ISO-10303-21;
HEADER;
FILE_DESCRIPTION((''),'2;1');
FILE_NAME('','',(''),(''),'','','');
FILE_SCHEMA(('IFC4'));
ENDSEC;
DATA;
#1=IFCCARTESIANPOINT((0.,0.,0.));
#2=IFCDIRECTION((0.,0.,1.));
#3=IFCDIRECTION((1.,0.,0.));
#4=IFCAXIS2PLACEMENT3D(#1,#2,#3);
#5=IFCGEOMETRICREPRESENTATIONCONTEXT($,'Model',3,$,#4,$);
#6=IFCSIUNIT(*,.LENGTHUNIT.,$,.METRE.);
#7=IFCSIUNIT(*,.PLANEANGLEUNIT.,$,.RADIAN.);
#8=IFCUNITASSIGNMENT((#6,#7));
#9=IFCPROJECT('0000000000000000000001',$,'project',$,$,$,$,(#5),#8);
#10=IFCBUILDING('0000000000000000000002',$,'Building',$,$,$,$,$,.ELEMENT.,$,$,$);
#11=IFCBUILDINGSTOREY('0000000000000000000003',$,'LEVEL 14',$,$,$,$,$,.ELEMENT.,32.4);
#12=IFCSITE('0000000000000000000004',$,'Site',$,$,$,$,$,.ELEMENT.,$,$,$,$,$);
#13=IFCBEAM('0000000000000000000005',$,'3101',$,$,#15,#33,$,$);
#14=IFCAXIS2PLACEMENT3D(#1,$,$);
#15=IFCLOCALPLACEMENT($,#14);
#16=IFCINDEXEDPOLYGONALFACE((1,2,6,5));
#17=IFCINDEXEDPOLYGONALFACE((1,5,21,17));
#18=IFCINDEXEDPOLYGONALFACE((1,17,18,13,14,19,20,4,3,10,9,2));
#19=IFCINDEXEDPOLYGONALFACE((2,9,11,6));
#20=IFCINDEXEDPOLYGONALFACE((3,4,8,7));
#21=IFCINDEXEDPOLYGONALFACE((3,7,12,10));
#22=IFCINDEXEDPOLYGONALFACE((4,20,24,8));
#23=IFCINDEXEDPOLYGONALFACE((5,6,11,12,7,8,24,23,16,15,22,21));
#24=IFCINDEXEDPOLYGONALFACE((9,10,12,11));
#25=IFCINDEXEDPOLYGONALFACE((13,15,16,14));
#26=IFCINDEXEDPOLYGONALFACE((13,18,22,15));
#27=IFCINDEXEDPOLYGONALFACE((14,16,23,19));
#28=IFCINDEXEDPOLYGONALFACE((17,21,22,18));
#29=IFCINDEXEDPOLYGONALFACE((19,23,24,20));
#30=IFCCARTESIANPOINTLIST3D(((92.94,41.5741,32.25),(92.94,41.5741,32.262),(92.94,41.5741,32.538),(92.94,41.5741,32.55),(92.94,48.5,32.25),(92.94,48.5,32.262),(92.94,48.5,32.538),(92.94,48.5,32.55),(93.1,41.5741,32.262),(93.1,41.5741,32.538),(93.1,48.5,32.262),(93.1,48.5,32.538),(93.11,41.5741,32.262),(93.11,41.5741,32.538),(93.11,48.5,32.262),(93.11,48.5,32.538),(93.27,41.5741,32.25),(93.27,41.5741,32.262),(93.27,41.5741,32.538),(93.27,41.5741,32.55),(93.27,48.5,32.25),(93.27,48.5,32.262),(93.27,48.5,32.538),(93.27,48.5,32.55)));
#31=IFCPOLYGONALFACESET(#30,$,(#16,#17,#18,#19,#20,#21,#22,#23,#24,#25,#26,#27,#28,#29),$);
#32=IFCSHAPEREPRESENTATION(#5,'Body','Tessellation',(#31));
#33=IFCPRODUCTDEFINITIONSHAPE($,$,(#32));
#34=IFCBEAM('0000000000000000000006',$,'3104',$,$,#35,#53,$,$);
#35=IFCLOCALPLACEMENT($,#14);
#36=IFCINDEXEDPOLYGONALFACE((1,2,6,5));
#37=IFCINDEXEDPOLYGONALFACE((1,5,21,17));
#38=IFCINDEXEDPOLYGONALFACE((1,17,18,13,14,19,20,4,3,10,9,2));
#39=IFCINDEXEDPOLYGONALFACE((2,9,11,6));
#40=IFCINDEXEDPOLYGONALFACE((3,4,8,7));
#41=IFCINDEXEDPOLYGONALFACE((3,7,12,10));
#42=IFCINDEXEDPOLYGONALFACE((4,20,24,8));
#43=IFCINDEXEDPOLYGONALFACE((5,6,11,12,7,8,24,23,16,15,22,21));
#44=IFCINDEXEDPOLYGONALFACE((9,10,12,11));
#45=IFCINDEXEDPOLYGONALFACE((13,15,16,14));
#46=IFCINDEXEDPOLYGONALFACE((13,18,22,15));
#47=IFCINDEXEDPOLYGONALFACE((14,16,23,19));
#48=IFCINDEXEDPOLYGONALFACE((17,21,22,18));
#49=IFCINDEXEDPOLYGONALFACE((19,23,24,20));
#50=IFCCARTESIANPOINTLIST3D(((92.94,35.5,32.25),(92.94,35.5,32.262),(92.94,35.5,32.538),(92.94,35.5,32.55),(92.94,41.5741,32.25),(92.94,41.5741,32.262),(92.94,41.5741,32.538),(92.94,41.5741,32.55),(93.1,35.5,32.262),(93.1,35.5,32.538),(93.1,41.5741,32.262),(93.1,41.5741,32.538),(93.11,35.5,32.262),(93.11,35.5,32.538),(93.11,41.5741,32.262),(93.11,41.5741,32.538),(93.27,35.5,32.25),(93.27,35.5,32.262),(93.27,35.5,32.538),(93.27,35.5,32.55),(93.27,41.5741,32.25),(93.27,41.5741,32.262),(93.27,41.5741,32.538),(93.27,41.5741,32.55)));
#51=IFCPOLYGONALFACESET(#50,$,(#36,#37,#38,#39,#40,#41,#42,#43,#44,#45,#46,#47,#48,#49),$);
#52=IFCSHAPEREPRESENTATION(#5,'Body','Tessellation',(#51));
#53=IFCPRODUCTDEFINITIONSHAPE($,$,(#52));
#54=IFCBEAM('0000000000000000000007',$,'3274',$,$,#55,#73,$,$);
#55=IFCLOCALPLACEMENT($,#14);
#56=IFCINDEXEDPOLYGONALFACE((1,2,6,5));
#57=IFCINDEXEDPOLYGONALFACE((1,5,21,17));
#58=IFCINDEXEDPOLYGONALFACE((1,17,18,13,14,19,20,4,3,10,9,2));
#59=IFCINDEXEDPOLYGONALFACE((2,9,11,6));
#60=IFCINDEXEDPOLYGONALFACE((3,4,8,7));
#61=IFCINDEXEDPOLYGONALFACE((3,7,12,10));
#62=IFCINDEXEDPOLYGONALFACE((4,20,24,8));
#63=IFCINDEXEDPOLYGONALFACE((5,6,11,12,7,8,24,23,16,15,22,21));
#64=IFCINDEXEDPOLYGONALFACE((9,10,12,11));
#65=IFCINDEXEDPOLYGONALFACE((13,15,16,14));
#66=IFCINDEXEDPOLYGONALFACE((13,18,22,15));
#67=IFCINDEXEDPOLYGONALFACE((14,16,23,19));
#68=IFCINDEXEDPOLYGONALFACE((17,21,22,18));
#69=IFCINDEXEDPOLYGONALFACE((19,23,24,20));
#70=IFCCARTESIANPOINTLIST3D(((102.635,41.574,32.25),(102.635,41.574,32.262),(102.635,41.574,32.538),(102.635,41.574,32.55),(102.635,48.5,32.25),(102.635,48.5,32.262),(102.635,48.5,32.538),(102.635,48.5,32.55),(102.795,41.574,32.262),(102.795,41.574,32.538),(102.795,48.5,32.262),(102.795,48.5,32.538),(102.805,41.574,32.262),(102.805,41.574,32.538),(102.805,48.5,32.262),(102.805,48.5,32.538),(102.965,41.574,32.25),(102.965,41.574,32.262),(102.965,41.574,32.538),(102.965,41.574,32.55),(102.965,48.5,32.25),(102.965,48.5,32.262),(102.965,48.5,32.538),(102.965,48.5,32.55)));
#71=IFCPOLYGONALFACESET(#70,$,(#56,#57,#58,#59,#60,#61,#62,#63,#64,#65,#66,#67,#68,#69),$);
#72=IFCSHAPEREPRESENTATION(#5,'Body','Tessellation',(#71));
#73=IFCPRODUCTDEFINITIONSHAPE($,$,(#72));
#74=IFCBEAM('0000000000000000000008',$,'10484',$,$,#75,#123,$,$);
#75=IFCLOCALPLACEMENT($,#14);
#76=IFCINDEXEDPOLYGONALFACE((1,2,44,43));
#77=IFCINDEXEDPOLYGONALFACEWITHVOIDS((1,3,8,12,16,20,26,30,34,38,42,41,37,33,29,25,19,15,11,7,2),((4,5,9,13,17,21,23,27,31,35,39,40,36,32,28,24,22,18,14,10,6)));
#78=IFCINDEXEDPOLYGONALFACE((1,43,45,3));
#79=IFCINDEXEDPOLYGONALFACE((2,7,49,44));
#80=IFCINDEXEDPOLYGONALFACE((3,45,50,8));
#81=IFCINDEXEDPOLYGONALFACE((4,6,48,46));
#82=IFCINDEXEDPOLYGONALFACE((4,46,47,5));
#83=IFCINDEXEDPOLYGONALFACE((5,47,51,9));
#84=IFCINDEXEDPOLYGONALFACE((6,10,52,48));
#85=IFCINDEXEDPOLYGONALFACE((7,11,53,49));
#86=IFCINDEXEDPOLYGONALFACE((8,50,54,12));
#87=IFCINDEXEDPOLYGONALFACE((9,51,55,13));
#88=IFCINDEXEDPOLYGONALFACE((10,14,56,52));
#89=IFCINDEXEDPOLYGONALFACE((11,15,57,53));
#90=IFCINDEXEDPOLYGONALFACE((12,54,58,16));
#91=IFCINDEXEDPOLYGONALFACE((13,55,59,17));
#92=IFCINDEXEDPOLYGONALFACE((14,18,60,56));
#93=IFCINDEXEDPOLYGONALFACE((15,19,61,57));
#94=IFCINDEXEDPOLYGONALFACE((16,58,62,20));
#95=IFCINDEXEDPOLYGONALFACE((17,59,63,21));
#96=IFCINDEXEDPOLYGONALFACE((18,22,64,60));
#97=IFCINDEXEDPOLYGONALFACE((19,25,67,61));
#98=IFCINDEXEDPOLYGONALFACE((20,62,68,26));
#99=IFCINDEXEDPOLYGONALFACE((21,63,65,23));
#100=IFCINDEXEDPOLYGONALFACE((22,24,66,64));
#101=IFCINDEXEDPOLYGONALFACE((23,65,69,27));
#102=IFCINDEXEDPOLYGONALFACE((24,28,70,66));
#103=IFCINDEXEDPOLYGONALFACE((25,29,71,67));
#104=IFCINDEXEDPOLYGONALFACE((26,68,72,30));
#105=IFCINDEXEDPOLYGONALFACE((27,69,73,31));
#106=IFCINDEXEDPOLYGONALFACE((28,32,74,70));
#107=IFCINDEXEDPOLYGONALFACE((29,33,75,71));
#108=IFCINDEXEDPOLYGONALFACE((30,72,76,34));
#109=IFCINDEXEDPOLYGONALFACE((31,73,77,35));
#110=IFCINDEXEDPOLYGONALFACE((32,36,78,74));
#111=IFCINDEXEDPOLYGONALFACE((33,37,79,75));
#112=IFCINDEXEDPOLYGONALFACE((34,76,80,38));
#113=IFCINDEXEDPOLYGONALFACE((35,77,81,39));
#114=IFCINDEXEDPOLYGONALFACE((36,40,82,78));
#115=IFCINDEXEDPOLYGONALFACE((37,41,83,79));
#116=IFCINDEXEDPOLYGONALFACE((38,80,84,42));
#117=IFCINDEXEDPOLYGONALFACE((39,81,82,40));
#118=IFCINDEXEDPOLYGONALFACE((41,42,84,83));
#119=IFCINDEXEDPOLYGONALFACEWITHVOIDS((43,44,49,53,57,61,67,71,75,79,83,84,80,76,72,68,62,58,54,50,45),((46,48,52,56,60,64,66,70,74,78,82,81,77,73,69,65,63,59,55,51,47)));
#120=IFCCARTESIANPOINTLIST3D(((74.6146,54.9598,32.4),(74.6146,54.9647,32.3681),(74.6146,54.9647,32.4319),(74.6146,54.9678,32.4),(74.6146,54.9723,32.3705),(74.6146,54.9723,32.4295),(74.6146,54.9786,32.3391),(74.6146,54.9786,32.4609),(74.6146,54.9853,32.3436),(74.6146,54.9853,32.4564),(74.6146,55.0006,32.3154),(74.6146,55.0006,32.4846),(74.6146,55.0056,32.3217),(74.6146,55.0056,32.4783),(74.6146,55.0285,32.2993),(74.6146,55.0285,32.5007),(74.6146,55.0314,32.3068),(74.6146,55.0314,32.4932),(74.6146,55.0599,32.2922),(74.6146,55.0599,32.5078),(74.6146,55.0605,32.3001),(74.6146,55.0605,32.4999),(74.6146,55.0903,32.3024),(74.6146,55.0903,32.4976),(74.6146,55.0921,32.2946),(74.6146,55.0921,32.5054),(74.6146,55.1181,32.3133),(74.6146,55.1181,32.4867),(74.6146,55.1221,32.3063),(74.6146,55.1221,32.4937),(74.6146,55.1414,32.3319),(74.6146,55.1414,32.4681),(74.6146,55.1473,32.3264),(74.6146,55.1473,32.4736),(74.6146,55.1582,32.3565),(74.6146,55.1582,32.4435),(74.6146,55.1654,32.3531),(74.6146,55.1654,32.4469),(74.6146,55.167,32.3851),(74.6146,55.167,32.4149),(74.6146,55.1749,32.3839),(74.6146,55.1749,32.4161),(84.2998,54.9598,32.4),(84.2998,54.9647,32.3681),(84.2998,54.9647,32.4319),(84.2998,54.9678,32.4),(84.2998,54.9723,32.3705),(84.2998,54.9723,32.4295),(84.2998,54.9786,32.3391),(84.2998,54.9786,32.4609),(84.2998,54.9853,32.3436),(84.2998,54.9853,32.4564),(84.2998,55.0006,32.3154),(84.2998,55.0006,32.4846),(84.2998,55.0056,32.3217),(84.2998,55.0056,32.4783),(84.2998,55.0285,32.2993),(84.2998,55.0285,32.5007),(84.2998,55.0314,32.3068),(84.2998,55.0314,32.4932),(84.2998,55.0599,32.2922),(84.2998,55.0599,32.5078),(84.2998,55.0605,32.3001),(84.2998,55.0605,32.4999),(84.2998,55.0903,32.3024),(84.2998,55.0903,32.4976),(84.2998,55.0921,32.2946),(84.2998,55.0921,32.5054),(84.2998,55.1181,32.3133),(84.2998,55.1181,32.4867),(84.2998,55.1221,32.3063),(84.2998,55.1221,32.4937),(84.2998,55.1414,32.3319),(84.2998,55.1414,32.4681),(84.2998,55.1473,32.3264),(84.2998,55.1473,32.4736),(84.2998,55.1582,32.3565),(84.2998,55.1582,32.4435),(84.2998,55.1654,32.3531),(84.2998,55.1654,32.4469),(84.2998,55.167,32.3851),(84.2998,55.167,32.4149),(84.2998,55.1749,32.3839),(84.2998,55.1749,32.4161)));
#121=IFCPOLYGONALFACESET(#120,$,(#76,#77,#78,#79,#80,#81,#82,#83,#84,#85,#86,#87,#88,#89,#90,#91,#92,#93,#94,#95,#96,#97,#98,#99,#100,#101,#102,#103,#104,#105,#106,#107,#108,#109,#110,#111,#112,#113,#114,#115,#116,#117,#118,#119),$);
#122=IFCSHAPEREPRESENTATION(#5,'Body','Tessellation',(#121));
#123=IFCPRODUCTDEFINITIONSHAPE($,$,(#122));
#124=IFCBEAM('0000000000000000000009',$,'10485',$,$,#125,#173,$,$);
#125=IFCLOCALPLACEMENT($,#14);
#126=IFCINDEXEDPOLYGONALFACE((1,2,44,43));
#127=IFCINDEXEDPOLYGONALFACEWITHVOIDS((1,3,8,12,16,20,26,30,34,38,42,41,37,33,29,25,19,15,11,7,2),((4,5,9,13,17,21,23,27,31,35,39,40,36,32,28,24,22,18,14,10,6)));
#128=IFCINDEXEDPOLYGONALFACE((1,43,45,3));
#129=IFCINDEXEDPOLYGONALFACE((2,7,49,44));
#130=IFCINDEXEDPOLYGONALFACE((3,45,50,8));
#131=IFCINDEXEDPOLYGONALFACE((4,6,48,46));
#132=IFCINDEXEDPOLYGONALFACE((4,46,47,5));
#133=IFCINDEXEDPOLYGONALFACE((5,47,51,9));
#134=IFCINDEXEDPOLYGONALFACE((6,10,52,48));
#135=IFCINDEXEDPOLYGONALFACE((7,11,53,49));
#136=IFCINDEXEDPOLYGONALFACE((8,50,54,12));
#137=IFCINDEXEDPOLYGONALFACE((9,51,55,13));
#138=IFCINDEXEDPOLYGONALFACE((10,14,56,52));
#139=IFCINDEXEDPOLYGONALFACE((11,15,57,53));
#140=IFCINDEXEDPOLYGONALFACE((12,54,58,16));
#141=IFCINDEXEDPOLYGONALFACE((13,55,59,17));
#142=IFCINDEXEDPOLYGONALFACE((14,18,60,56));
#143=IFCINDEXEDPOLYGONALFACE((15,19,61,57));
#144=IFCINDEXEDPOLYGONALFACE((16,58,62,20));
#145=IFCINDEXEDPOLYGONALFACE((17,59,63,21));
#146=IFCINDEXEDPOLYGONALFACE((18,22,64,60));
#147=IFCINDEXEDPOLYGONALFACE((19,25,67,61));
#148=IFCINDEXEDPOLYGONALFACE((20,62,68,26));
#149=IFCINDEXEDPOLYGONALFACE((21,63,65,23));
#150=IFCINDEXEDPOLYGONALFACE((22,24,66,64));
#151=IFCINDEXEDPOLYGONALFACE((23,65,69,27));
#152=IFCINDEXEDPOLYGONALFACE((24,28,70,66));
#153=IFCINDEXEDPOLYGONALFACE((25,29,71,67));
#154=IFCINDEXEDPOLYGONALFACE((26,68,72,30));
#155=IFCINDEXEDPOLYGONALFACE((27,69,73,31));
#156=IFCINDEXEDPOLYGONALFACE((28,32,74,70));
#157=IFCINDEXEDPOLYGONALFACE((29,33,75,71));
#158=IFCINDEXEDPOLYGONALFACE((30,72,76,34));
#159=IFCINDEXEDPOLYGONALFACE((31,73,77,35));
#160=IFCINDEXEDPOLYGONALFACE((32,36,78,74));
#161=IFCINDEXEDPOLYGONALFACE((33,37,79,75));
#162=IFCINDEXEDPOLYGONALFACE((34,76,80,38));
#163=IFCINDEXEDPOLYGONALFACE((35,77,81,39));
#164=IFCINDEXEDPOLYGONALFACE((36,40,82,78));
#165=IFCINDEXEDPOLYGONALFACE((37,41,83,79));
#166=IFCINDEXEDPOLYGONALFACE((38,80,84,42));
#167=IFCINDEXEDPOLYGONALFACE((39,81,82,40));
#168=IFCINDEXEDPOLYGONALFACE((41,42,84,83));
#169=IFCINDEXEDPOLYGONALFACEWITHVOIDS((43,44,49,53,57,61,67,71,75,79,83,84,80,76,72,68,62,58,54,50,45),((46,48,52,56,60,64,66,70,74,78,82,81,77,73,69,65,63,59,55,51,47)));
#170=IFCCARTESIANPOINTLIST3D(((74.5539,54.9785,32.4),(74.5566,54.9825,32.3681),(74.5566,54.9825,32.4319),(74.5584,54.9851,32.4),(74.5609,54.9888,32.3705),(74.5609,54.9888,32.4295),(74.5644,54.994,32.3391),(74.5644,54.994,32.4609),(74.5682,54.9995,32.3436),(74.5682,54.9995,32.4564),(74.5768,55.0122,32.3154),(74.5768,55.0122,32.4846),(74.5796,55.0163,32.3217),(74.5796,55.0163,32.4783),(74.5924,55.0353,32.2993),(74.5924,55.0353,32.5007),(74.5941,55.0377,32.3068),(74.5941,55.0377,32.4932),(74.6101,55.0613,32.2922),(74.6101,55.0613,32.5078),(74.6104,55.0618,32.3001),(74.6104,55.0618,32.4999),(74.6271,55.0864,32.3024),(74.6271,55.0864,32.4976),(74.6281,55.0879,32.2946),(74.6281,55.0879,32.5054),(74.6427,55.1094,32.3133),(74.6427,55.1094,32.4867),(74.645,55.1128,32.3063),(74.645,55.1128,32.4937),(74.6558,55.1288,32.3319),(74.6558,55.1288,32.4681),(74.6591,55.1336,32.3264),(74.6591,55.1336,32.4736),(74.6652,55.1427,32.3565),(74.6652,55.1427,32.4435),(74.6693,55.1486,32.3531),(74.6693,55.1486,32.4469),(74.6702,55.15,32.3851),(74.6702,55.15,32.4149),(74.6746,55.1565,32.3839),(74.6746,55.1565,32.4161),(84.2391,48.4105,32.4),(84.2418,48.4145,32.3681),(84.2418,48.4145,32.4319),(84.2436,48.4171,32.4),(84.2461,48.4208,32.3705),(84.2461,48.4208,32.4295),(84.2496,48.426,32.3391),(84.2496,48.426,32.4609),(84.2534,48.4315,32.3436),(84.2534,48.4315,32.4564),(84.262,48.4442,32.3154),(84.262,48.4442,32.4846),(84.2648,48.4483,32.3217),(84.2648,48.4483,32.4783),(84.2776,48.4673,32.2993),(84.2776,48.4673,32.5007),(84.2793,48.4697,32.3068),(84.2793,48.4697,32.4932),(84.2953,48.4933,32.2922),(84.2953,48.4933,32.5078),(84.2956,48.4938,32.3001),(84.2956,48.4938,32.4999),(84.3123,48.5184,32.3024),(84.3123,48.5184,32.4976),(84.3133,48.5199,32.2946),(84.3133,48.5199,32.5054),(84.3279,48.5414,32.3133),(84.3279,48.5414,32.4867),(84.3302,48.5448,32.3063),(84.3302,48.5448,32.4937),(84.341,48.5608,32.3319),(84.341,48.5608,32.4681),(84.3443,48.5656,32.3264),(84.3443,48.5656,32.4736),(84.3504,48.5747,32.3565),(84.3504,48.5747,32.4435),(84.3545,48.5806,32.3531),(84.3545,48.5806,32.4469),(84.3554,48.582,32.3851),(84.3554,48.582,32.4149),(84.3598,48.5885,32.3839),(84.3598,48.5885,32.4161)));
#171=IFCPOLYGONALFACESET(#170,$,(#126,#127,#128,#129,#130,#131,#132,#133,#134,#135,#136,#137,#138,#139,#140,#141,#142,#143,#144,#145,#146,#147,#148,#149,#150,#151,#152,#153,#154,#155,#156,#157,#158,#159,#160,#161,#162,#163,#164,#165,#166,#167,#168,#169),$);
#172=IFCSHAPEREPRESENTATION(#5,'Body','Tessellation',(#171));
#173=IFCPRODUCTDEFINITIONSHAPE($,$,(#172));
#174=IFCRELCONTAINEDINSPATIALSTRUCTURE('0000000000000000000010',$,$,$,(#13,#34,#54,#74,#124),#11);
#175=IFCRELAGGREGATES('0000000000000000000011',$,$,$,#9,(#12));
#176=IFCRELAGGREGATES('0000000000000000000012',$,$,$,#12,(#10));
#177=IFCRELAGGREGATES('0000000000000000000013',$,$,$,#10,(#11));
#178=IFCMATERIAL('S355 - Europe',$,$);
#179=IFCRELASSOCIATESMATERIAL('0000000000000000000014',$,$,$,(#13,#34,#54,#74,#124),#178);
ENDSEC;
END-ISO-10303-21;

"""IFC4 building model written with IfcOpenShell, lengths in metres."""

from ifc_helpers import new_model, si_unit, frame, origin_with_axes, origin_2d_with_axis, place, context, project, spatial, hollow_circle, i_section, extrude, material, material_profile, profile_set, profile_usage, element, save


model = new_model("IFC4")

# Units and contexts
model_context = context("Model", 3, world=origin_with_axes())
ifc_project = project(units=[si_unit("LENGTHUNIT", "METRE"), si_unit("PLANEANGLEUNIT", "RADIAN")], contexts=[model_context])

# Site, building, storey
site = spatial("IfcSite", under=ifc_project, Name="Site", CompositionType="ELEMENT")
building = spatial("IfcBuilding", under=site, Name="Building", CompositionType="ELEMENT")
storey = spatial("IfcBuildingStorey", under=building, Name="LEVEL 14", CompositionType="ELEMENT", Elevation=32.4)

# Shared definitions
ifc_material = material(Name="S355 - Europe")

# Beams
ifc_material_profile_1 = material_profile(ifc_material, i_section(OverallWidth=0.33, OverallDepth=0.3, WebThickness=0.01, FlangeThickness=0.012, at=origin_2d_with_axis()))
ifc_profile_set_1 = profile_set([ifc_material_profile_1])
ifc_profile_usage_1 = profile_usage(ifc_profile_set_1, cardinal=10)
beam_1_placement = place(None, frame((93.105, 48.5, 32.4), z_axis=(0.0, -1.0, 0.0), x_axis=(1.0, 0.0, 0.0)))
element("IfcBeam", 1, at=beam_1_placement, inside=storey, material=ifc_profile_usage_1, Name="3101", context=model_context, shape_type="SweptSolid", body=[
    extrude(i_section(OverallWidth=0.33, OverallDepth=0.3, WebThickness=0.01, FlangeThickness=0.012, at=origin_2d_with_axis()), origin_with_axes(), (0.0, 0.0, 1.0), 6.9259),
])
ifc_material_profile_2 = material_profile(ifc_material, i_section(OverallWidth=0.33, OverallDepth=0.3, WebThickness=0.01, FlangeThickness=0.012, at=origin_2d_with_axis()))
ifc_profile_set_2 = profile_set([ifc_material_profile_2])
ifc_profile_usage_2 = profile_usage(ifc_profile_set_2, cardinal=10)
beam_2_placement = place(None, frame((93.105, 41.5741, 32.4), z_axis=(0.0, -1.0, 0.0), x_axis=(1.0, 0.0, 0.0)))
element("IfcBeam", 2, at=beam_2_placement, inside=storey, material=ifc_profile_usage_2, Name="3104", context=model_context, shape_type="SweptSolid", body=[
    extrude(i_section(OverallWidth=0.33, OverallDepth=0.3, WebThickness=0.01, FlangeThickness=0.012, at=origin_2d_with_axis()), origin_with_axes(), (0.0, 0.0, 1.0), 6.0741),
])
ifc_material_profile_3 = material_profile(ifc_material, i_section(OverallWidth=0.33, OverallDepth=0.3, WebThickness=0.01, FlangeThickness=0.012, at=origin_2d_with_axis()))
ifc_profile_set_3 = profile_set([ifc_material_profile_3])
ifc_profile_usage_3 = profile_usage(ifc_profile_set_3, cardinal=10)
beam_3_placement = place(None, frame((102.8, 48.5, 32.4), z_axis=(0.0, -1.0, 0.0), x_axis=(1.0, 0.0, 0.0)))
element("IfcBeam", 3, at=beam_3_placement, inside=storey, material=ifc_profile_usage_3, Name="3274", context=model_context, shape_type="SweptSolid", body=[
    extrude(i_section(OverallWidth=0.33, OverallDepth=0.3, WebThickness=0.01, FlangeThickness=0.012, at=origin_2d_with_axis()), origin_with_axes(), (0.0, 0.0, 1.0), 6.926),
])
ifc_material_profile_4 = material_profile(ifc_material, hollow_circle(Radius=0.1081, WallThickness=0.008, at=origin_2d_with_axis()))
ifc_profile_set_4 = profile_set([ifc_material_profile_4])
ifc_profile_usage_4 = profile_usage(ifc_profile_set_4, cardinal=10)
beam_4_placement = place(None, frame((84.2998, 55.068, 32.4), z_axis=(-1.0, 0.0, 0.0), x_axis=(0.0, -1.0, 0.0)))
element("IfcBeam", 4, at=beam_4_placement, inside=storey, material=ifc_profile_usage_4, Name="10484", context=model_context, shape_type="SweptSolid", body=[
    extrude(hollow_circle(Radius=0.1081, WallThickness=0.008, at=origin_2d_with_axis()), origin_with_axes(), (0.0, 0.0, 1.0), 9.6852),
])
ifc_material_profile_5 = material_profile(ifc_material, hollow_circle(Radius=0.1081, WallThickness=0.008, at=origin_2d_with_axis()))
ifc_profile_set_5 = profile_set([ifc_material_profile_5])
ifc_profile_usage_5 = profile_usage(ifc_profile_set_5, cardinal=10)
beam_5_placement = place(None, frame((84.2998, 48.5, 32.4), z_axis=(-0.827639, 0.561261, 0.0), x_axis=(-0.561261, -0.827639, 0.0)))
element("IfcBeam", 5, at=beam_5_placement, inside=storey, material=ifc_profile_usage_5, Name="10485", context=model_context, shape_type="SweptSolid", body=[
    extrude(hollow_circle(Radius=0.1081, WallThickness=0.008, at=origin_2d_with_axis()), origin_with_axes(), (0.0, 0.0, 1.0), 11.7022),
])

save(model, "model.ifc")
